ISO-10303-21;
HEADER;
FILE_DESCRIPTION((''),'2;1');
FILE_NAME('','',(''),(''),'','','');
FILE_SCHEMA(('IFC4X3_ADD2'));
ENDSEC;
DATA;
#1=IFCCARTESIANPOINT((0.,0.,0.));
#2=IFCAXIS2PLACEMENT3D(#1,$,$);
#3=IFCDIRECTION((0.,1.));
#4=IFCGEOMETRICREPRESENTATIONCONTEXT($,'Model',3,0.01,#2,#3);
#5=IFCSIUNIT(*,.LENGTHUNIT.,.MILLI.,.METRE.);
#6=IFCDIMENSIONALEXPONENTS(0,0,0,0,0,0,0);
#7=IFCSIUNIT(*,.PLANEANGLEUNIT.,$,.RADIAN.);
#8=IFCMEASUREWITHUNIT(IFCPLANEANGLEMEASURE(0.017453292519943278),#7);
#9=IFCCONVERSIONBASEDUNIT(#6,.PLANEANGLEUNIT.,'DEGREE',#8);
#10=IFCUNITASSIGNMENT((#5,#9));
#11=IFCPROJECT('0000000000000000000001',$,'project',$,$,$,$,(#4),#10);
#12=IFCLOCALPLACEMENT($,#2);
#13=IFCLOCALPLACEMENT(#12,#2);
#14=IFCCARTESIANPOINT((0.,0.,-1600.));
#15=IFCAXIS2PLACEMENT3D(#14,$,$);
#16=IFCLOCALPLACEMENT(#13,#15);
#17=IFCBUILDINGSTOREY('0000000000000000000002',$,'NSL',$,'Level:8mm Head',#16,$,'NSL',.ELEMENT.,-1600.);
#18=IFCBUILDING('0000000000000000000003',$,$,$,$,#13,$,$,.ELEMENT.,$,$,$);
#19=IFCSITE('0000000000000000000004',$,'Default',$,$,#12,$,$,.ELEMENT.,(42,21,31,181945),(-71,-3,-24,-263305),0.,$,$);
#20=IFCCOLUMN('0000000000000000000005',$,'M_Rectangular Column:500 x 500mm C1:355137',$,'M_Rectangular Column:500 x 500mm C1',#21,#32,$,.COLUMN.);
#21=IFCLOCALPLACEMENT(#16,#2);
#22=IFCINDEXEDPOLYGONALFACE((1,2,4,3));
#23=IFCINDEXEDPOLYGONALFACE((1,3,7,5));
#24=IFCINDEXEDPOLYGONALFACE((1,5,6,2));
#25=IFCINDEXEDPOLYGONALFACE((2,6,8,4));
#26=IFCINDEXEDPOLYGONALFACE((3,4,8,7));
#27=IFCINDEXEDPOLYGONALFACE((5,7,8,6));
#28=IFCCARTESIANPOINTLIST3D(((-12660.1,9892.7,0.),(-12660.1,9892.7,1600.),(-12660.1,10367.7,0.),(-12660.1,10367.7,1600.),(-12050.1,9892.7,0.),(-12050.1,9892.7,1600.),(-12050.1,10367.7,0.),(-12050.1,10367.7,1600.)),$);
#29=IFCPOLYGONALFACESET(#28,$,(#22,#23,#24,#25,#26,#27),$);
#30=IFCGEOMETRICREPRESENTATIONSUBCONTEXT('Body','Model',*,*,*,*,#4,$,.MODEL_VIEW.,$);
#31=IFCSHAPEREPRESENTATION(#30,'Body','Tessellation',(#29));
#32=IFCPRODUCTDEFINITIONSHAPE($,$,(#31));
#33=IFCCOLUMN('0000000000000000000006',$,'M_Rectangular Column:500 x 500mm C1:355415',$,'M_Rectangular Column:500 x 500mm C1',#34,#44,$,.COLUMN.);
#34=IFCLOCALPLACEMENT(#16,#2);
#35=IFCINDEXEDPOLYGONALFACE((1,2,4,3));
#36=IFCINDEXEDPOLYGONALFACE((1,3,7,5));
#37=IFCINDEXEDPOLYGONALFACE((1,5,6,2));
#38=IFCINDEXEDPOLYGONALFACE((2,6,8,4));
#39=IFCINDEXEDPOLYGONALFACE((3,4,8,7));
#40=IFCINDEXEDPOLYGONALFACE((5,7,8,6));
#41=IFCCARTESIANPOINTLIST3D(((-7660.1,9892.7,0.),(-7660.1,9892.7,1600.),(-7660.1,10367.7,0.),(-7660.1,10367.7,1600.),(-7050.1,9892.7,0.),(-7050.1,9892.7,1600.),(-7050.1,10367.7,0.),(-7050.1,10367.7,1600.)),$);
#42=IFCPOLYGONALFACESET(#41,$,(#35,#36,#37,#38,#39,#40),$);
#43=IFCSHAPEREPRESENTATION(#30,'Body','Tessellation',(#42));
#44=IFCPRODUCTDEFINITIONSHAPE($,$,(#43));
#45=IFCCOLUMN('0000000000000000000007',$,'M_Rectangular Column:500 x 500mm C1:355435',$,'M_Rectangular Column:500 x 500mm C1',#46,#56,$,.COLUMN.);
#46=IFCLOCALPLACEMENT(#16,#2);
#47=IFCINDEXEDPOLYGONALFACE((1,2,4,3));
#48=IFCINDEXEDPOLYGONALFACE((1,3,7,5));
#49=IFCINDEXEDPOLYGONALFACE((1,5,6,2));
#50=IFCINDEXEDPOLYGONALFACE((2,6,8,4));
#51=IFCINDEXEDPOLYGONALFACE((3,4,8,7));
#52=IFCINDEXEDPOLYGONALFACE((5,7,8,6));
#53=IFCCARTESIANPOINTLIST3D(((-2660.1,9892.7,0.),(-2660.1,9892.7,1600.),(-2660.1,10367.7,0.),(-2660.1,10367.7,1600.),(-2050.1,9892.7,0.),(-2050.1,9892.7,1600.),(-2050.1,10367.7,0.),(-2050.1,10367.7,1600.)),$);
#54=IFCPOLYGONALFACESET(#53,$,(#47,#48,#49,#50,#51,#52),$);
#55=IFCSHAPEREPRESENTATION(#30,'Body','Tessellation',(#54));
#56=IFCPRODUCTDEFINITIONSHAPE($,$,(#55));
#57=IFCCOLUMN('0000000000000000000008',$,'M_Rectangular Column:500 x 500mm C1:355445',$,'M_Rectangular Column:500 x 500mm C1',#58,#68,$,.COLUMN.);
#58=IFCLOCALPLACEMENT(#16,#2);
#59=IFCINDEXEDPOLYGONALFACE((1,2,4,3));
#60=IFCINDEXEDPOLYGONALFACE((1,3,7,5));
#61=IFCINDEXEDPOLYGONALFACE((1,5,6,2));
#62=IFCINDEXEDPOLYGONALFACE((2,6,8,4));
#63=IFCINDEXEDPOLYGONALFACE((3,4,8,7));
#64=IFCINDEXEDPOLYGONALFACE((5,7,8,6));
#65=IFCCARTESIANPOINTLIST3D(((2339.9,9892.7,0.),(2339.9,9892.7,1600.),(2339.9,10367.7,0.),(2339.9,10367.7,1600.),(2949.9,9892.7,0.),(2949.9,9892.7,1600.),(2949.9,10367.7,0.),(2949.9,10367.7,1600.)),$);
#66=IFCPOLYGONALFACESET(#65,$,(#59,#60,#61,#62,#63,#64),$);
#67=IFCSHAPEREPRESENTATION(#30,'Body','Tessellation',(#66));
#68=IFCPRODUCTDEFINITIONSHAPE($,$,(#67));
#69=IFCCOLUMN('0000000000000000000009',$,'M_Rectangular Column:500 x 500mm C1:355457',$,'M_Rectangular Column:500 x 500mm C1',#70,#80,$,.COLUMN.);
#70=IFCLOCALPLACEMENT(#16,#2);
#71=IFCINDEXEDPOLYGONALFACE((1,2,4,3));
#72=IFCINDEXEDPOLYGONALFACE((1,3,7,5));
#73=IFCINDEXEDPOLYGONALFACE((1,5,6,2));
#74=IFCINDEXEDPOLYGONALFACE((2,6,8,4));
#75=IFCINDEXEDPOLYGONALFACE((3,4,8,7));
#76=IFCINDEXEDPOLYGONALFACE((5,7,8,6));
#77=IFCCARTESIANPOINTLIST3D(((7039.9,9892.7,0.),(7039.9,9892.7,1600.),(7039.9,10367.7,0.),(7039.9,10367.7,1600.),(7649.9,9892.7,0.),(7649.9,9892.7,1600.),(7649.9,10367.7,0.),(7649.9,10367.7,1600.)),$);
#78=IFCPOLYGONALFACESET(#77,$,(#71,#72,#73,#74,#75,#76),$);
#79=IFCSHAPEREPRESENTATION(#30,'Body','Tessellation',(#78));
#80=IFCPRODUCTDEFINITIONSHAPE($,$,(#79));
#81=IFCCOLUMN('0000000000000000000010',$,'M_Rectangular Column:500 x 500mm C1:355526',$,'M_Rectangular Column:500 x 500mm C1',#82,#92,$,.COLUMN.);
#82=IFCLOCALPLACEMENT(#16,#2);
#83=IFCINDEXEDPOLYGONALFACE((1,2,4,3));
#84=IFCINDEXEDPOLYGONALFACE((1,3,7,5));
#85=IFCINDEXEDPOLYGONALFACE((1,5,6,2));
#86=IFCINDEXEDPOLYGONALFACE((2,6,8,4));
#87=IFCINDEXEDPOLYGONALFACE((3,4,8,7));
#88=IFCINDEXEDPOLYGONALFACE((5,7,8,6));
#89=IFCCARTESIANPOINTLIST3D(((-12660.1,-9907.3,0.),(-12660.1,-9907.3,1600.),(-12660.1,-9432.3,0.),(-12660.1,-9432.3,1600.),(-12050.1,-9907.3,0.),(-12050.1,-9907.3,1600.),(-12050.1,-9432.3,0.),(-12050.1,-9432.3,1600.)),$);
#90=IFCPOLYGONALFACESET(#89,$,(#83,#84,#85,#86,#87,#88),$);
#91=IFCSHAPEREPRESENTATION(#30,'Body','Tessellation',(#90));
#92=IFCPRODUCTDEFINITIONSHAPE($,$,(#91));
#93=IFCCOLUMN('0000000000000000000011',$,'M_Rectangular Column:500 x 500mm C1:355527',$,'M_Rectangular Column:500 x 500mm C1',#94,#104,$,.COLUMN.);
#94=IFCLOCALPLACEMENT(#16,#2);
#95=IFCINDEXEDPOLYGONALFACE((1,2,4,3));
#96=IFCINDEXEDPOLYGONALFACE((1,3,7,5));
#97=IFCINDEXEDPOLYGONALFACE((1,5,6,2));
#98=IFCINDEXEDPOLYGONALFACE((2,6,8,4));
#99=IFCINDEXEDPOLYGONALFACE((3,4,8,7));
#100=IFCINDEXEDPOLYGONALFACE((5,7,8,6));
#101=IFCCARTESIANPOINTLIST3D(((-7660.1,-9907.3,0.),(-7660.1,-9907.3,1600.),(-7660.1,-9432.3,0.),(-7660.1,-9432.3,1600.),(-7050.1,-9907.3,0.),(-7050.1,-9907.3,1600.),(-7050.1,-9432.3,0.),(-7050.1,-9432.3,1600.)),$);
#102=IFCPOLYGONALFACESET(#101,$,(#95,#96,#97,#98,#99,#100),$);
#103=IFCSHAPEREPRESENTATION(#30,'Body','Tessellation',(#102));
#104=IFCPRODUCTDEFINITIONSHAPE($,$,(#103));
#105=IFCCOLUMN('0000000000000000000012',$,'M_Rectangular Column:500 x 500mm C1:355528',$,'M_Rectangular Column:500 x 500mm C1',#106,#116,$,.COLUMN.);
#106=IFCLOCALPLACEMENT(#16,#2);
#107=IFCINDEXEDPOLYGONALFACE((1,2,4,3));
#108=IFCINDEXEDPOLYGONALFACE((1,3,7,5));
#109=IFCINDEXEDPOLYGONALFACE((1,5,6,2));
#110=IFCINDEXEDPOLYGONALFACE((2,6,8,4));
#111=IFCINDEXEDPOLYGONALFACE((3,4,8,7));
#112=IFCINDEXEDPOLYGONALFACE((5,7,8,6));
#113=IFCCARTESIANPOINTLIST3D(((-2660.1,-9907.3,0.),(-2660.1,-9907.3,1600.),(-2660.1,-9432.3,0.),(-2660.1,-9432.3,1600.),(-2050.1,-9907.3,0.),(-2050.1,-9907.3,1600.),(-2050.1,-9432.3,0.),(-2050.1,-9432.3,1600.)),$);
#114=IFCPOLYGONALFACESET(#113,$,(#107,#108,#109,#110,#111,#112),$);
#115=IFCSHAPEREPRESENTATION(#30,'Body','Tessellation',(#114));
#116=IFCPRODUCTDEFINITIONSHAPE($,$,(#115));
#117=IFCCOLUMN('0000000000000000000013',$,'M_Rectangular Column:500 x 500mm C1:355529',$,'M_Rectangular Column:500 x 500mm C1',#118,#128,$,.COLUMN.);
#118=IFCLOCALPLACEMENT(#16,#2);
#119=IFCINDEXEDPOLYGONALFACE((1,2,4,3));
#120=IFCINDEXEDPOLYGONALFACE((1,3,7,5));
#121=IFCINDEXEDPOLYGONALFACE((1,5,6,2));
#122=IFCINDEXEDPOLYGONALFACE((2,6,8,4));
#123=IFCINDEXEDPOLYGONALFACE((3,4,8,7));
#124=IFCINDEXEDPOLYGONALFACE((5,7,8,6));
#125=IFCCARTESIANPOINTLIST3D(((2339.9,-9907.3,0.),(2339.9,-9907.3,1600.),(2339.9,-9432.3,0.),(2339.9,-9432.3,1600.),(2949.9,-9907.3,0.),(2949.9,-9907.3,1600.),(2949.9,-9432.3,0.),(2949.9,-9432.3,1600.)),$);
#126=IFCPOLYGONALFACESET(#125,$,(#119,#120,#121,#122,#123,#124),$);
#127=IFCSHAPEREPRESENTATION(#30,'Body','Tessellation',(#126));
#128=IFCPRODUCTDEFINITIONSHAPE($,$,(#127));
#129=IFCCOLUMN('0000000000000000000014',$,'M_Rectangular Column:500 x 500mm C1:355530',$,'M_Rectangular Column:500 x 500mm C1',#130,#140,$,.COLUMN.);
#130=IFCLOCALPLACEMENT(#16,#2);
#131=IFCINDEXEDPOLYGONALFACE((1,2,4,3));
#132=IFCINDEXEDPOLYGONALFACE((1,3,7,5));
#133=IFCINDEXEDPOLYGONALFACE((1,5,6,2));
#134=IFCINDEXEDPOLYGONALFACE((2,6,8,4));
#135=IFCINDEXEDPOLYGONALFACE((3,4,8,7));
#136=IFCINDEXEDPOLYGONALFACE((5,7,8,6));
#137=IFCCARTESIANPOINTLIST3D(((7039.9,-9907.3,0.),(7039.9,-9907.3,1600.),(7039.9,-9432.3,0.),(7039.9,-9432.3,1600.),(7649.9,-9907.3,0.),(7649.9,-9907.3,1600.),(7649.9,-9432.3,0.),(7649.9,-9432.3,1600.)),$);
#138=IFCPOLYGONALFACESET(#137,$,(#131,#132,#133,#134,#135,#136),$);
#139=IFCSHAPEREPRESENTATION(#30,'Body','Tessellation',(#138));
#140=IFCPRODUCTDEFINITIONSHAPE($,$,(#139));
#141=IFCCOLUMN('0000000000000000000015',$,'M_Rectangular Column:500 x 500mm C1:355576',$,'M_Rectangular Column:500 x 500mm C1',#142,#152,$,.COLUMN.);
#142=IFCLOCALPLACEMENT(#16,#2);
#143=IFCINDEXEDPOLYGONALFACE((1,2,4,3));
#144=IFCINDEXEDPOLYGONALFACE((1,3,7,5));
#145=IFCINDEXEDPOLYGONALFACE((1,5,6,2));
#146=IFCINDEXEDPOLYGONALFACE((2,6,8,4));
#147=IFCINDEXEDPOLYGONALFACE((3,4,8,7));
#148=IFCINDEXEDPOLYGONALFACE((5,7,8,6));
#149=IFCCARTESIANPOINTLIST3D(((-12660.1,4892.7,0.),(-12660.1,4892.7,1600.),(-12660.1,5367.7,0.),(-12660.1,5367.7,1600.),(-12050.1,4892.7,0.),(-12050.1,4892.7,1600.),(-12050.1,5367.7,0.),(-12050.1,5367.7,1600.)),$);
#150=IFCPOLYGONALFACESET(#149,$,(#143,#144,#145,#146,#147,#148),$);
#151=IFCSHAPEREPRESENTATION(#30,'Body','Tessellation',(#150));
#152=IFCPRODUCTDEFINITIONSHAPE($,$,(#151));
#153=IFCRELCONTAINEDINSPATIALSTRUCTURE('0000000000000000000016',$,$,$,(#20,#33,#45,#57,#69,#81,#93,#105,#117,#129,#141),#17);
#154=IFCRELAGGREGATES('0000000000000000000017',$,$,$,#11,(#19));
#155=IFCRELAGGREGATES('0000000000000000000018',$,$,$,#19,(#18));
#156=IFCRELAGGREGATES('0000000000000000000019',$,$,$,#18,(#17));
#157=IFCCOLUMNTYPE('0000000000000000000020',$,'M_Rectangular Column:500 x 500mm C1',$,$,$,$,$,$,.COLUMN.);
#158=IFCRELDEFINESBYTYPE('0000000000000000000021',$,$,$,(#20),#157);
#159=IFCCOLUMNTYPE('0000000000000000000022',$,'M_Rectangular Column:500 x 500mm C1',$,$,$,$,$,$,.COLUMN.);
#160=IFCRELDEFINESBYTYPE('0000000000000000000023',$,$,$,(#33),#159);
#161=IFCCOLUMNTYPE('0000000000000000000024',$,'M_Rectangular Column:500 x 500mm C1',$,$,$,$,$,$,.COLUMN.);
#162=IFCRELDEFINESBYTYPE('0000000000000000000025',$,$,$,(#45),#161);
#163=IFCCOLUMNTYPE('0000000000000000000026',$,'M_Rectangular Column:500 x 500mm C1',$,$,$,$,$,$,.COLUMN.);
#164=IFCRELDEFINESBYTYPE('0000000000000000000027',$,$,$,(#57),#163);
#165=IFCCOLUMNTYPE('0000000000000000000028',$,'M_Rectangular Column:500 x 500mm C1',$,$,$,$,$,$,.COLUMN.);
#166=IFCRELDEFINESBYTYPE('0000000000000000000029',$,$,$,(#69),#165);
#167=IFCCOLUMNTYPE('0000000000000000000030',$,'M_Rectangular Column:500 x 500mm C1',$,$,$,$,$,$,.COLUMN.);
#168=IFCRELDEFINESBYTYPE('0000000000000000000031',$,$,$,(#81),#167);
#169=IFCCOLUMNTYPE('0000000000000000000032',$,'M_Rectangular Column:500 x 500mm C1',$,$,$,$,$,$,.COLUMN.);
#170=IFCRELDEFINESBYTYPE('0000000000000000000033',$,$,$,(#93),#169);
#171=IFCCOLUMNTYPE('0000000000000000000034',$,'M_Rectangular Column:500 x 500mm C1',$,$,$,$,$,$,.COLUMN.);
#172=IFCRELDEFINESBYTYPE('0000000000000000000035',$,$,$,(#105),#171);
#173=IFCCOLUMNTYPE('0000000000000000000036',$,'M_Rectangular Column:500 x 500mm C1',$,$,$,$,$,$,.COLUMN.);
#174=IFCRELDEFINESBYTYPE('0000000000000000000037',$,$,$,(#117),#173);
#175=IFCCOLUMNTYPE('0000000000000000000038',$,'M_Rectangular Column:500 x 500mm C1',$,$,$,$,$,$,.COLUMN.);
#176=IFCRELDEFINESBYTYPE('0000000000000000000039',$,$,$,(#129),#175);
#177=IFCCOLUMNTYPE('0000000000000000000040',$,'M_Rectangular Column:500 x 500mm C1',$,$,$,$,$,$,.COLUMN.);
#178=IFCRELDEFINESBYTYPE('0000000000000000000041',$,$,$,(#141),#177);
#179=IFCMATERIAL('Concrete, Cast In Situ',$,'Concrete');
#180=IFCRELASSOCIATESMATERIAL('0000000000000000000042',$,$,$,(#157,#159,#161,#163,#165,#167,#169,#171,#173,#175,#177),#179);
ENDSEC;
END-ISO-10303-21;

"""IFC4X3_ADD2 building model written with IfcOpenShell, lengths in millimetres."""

from ifc_helpers import new_model, entity, si_unit, converted_unit, direction, frame, frame_2d, origin, origin_2d_with_axis, place, context, subcontext, project, spatial, rectangle, extrude, source, transform, mapped, material, material_profile, profile_set, type_object, type_shapes, element, save


model = new_model("IFC4X3_ADD2")

# Units and contexts
model_context = context("Model", 3, precision=0.01, world=origin(), true_north=direction((0.0, 1.0)))
body_context = subcontext(model_context, "Body", "Model", "MODEL_VIEW")
ifc_project = project(units=[si_unit("LENGTHUNIT", "METRE", prefix="MILLI"), converted_unit("PLANEANGLEUNIT", "DEGREE", entity("IfcPlaneAngleMeasure", 0.017453292519943278), si_unit("PLANEANGLEUNIT", "RADIAN"), dimensions=[0, 0, 0, 0, 0, 0, 0])], contexts=[model_context])

# Site, building, storey
site_placement = place(None, origin())
site = spatial("IfcSite", under=ifc_project, at=site_placement, Name="Default", CompositionType="ELEMENT", RefLatitude=(42, 21, 31, 181945), RefLongitude=(-71, -3, -24, -263305), RefElevation=0.0)
building_placement = place(site_placement, origin())
building = spatial("IfcBuilding", under=site, at=building_placement, CompositionType="ELEMENT")
storey_placement = place(building_placement, frame((0.0, 0.0, -1600.0)))
storey = spatial("IfcBuildingStorey", under=building, at=storey_placement, Name="NSL", ObjectType="Level:8mm Head", LongName="NSL", CompositionType="ELEMENT", Elevation=-1600.0)

# Columns
ifc_material_1 = material(Name="Concrete, Cast In Situ", Category="Concrete")
ifc_material_profile_1 = material_profile(ifc_material_1, rectangle(XDim=610.0, YDim=475.0, at=frame_2d((0.0, 0.0), x_axis=(1.0, 0.0))), Name="500 x 500mm C1")
ifc_profile_set_1 = profile_set([ifc_material_profile_1], Name="500 x 500mm C1")
column_type_1 = type_object("IfcColumnType", Name="M_Rectangular Column:500 x 500mm C1", PredefinedType="COLUMN", material=ifc_profile_set_1)
shared_shape_1 = source(origin(), body_context, "Body", "SweptSolid", [
    extrude(rectangle(XDim=610.0, YDim=475.0, at=frame_2d((0.0, 0.0), x_axis=(1.0, 0.0))), frame((-12355.1, 10130.2, -1600.0), z_axis=(0.0, 0.0, 1.0), x_axis=(-1.0, 0.0, 0.0)), (0.0, 0.0, 1.0), 1600.0),
])
type_shapes(column_type_1, [shared_shape_1])
column_1_placement = place(storey_placement, frame((0.0, 0.0, 1600.0)))
element("IfcColumn", 1, at=column_1_placement, inside=storey, type_object=column_type_1, Name="M_Rectangular Column:500 x 500mm C1:355137", ObjectType="M_Rectangular Column:500 x 500mm C1", PredefinedType="COLUMN", context=body_context, shape_type="MappedRepresentation", body=[
    mapped(shared_shape_1, transform((0.0, 0.0, 0.0), scale=1.0)),
])
column_type_2 = type_object("IfcColumnType", Name="M_Rectangular Column:500 x 500mm C1", PredefinedType="COLUMN", material=ifc_profile_set_1)
shared_shape_2 = source(origin(), body_context, "Body", "SweptSolid", [
    extrude(rectangle(XDim=610.0, YDim=475.0, at=frame_2d((0.0, 0.0), x_axis=(1.0, 0.0))), frame((-7355.1, 10130.2, -1600.0), z_axis=(0.0, 0.0, 1.0), x_axis=(-1.0, 0.0, 0.0)), (0.0, 0.0, 1.0), 1600.0),
])
type_shapes(column_type_2, [shared_shape_2])
column_2_placement = place(storey_placement, frame((0.0, 0.0, 1600.0)))
element("IfcColumn", 2, at=column_2_placement, inside=storey, type_object=column_type_2, Name="M_Rectangular Column:500 x 500mm C1:355415", ObjectType="M_Rectangular Column:500 x 500mm C1", PredefinedType="COLUMN", context=body_context, shape_type="MappedRepresentation", body=[
    mapped(shared_shape_2, transform((0.0, 0.0, 0.0), scale=1.0)),
])
column_type_3 = type_object("IfcColumnType", Name="M_Rectangular Column:500 x 500mm C1", PredefinedType="COLUMN", material=ifc_profile_set_1)
shared_shape_3 = source(origin(), body_context, "Body", "SweptSolid", [
    extrude(rectangle(XDim=610.0, YDim=475.0, at=frame_2d((0.0, 0.0), x_axis=(1.0, 0.0))), frame((-2355.1, 10130.2, -1600.0), z_axis=(0.0, 0.0, 1.0), x_axis=(-1.0, 0.0, 0.0)), (0.0, 0.0, 1.0), 1600.0),
])
type_shapes(column_type_3, [shared_shape_3])
column_3_placement = place(storey_placement, frame((0.0, 0.0, 1600.0)))
element("IfcColumn", 3, at=column_3_placement, inside=storey, type_object=column_type_3, Name="M_Rectangular Column:500 x 500mm C1:355435", ObjectType="M_Rectangular Column:500 x 500mm C1", PredefinedType="COLUMN", context=body_context, shape_type="MappedRepresentation", body=[
    mapped(shared_shape_3, transform((0.0, 0.0, 0.0), scale=1.0)),
])
column_type_4 = type_object("IfcColumnType", Name="M_Rectangular Column:500 x 500mm C1", PredefinedType="COLUMN", material=ifc_profile_set_1)
shared_shape_4 = source(origin(), body_context, "Body", "SweptSolid", [
    extrude(rectangle(XDim=610.0, YDim=475.0, at=frame_2d((0.0, 0.0), x_axis=(1.0, 0.0))), frame((2644.9, 10130.2, -1600.0), z_axis=(0.0, 0.0, 1.0), x_axis=(-1.0, 0.0, 0.0)), (0.0, 0.0, 1.0), 1600.0),
])
type_shapes(column_type_4, [shared_shape_4])
column_4_placement = place(storey_placement, frame((0.0, 0.0, 1600.0)))
element("IfcColumn", 4, at=column_4_placement, inside=storey, type_object=column_type_4, Name="M_Rectangular Column:500 x 500mm C1:355445", ObjectType="M_Rectangular Column:500 x 500mm C1", PredefinedType="COLUMN", context=body_context, shape_type="MappedRepresentation", body=[
    mapped(shared_shape_4, transform((0.0, 0.0, 0.0), scale=1.0)),
])
column_type_5 = type_object("IfcColumnType", Name="M_Rectangular Column:500 x 500mm C1", PredefinedType="COLUMN", material=ifc_profile_set_1)
shared_shape_5 = source(origin(), body_context, "Body", "SweptSolid", [
    extrude(rectangle(XDim=610.0, YDim=475.0, at=frame_2d((0.0, 0.0), x_axis=(1.0, 0.0))), frame((7344.9, 10130.2, -1600.0), z_axis=(0.0, 0.0, 1.0), x_axis=(-1.0, 0.0, 0.0)), (0.0, 0.0, 1.0), 1600.0),
])
type_shapes(column_type_5, [shared_shape_5])
column_5_placement = place(storey_placement, frame((0.0, 0.0, 1600.0)))
element("IfcColumn", 5, at=column_5_placement, inside=storey, type_object=column_type_5, Name="M_Rectangular Column:500 x 500mm C1:355457", ObjectType="M_Rectangular Column:500 x 500mm C1", PredefinedType="COLUMN", context=body_context, shape_type="MappedRepresentation", body=[
    mapped(shared_shape_5, transform((0.0, 0.0, 0.0), scale=1.0)),
])
column_type_6 = type_object("IfcColumnType", Name="M_Rectangular Column:500 x 500mm C1", PredefinedType="COLUMN", material=ifc_profile_set_1)
shared_shape_6 = source(origin(), body_context, "Body", "SweptSolid", [
    extrude(rectangle(XDim=610.0, YDim=475.0, at=origin_2d_with_axis()), frame((-12355.1, -9669.8, -1600.0), z_axis=(0.0, 0.0, 1.0), x_axis=(-1.0, 0.0, 0.0)), (0.0, 0.0, 1.0), 1600.0),
])
type_shapes(column_type_6, [shared_shape_6])
column_6_placement = place(storey_placement, frame((0.0, 0.0, 1600.0)))
element("IfcColumn", 6, at=column_6_placement, inside=storey, type_object=column_type_6, Name="M_Rectangular Column:500 x 500mm C1:355526", ObjectType="M_Rectangular Column:500 x 500mm C1", PredefinedType="COLUMN", context=body_context, shape_type="MappedRepresentation", body=[
    mapped(shared_shape_6, transform((0.0, 0.0, 0.0), scale=1.0)),
])
column_type_7 = type_object("IfcColumnType", Name="M_Rectangular Column:500 x 500mm C1", PredefinedType="COLUMN", material=ifc_profile_set_1)
shared_shape_7 = source(origin(), body_context, "Body", "SweptSolid", [
    extrude(rectangle(XDim=610.0, YDim=475.0, at=frame_2d((0.0, 0.0), x_axis=(1.0, 0.0))), frame((-7355.1, -9669.8, -1600.0), z_axis=(0.0, 0.0, 1.0), x_axis=(-1.0, 0.0, 0.0)), (0.0, 0.0, 1.0), 1600.0),
])
type_shapes(column_type_7, [shared_shape_7])
column_7_placement = place(storey_placement, frame((0.0, 0.0, 1600.0)))
element("IfcColumn", 7, at=column_7_placement, inside=storey, type_object=column_type_7, Name="M_Rectangular Column:500 x 500mm C1:355527", ObjectType="M_Rectangular Column:500 x 500mm C1", PredefinedType="COLUMN", context=body_context, shape_type="MappedRepresentation", body=[
    mapped(shared_shape_7, transform((0.0, 0.0, 0.0), scale=1.0)),
])
column_type_8 = type_object("IfcColumnType", Name="M_Rectangular Column:500 x 500mm C1", PredefinedType="COLUMN", material=ifc_profile_set_1)
shared_shape_8 = source(origin(), body_context, "Body", "SweptSolid", [
    extrude(rectangle(XDim=610.0, YDim=475.0, at=frame_2d((0.0, 0.0), x_axis=(1.0, 0.0))), frame((-2355.1, -9669.8, -1600.0), z_axis=(0.0, 0.0, 1.0), x_axis=(-1.0, 0.0, 0.0)), (0.0, 0.0, 1.0), 1600.0),
])
type_shapes(column_type_8, [shared_shape_8])
column_8_placement = place(storey_placement, frame((0.0, 0.0, 1600.0)))
element("IfcColumn", 8, at=column_8_placement, inside=storey, type_object=column_type_8, Name="M_Rectangular Column:500 x 500mm C1:355528", ObjectType="M_Rectangular Column:500 x 500mm C1", PredefinedType="COLUMN", context=body_context, shape_type="MappedRepresentation", body=[
    mapped(shared_shape_8, transform((0.0, 0.0, 0.0), scale=1.0)),
])
column_type_9 = type_object("IfcColumnType", Name="M_Rectangular Column:500 x 500mm C1", PredefinedType="COLUMN", material=ifc_profile_set_1)
shared_shape_9 = source(origin(), body_context, "Body", "SweptSolid", [
    extrude(rectangle(XDim=610.0, YDim=475.0, at=frame_2d((0.0, 0.0), x_axis=(1.0, 0.0))), frame((2644.9, -9669.8, -1600.0), z_axis=(0.0, 0.0, 1.0), x_axis=(-1.0, 0.0, 0.0)), (0.0, 0.0, 1.0), 1600.0),
])
type_shapes(column_type_9, [shared_shape_9])
column_9_placement = place(storey_placement, frame((0.0, 0.0, 1600.0)))
element("IfcColumn", 9, at=column_9_placement, inside=storey, type_object=column_type_9, Name="M_Rectangular Column:500 x 500mm C1:355529", ObjectType="M_Rectangular Column:500 x 500mm C1", PredefinedType="COLUMN", context=body_context, shape_type="MappedRepresentation", body=[
    mapped(shared_shape_9, transform((0.0, 0.0, 0.0), scale=1.0)),
])
column_type_10 = type_object("IfcColumnType", Name="M_Rectangular Column:500 x 500mm C1", PredefinedType="COLUMN", material=ifc_profile_set_1)
shared_shape_10 = source(origin(), body_context, "Body", "SweptSolid", [
    extrude(rectangle(XDim=610.0, YDim=475.0, at=origin_2d_with_axis()), frame((7344.9, -9669.8, -1600.0), z_axis=(0.0, 0.0, 1.0), x_axis=(-1.0, 0.0, 0.0)), (0.0, 0.0, 1.0), 1600.0),
])
type_shapes(column_type_10, [shared_shape_10])
column_10_placement = place(storey_placement, frame((0.0, 0.0, 1600.0)))
element("IfcColumn", 10, at=column_10_placement, inside=storey, type_object=column_type_10, Name="M_Rectangular Column:500 x 500mm C1:355530", ObjectType="M_Rectangular Column:500 x 500mm C1", PredefinedType="COLUMN", context=body_context, shape_type="MappedRepresentation", body=[
    mapped(shared_shape_10, transform((0.0, 0.0, 0.0), scale=1.0)),
])
column_type_11 = type_object("IfcColumnType", Name="M_Rectangular Column:500 x 500mm C1", PredefinedType="COLUMN", material=ifc_profile_set_1)
shared_shape_11 = source(origin(), body_context, "Body", "SweptSolid", [
    extrude(rectangle(XDim=610.0, YDim=475.0, at=frame_2d((0.0, 0.0), x_axis=(1.0, 0.0))), frame((-12355.1, 5130.2, -1600.0), z_axis=(0.0, 0.0, 1.0), x_axis=(-1.0, 0.0, 0.0)), (0.0, 0.0, 1.0), 1600.0),
])
type_shapes(column_type_11, [shared_shape_11])
column_11_placement = place(storey_placement, frame((0.0, 0.0, 1600.0)))
element("IfcColumn", 11, at=column_11_placement, inside=storey, type_object=column_type_11, Name="M_Rectangular Column:500 x 500mm C1:355576", ObjectType="M_Rectangular Column:500 x 500mm C1", PredefinedType="COLUMN", context=body_context, shape_type="MappedRepresentation", body=[
    mapped(shared_shape_11, transform((0.0, 0.0, 0.0), scale=1.0)),
])

save(model, "model.ifc")
